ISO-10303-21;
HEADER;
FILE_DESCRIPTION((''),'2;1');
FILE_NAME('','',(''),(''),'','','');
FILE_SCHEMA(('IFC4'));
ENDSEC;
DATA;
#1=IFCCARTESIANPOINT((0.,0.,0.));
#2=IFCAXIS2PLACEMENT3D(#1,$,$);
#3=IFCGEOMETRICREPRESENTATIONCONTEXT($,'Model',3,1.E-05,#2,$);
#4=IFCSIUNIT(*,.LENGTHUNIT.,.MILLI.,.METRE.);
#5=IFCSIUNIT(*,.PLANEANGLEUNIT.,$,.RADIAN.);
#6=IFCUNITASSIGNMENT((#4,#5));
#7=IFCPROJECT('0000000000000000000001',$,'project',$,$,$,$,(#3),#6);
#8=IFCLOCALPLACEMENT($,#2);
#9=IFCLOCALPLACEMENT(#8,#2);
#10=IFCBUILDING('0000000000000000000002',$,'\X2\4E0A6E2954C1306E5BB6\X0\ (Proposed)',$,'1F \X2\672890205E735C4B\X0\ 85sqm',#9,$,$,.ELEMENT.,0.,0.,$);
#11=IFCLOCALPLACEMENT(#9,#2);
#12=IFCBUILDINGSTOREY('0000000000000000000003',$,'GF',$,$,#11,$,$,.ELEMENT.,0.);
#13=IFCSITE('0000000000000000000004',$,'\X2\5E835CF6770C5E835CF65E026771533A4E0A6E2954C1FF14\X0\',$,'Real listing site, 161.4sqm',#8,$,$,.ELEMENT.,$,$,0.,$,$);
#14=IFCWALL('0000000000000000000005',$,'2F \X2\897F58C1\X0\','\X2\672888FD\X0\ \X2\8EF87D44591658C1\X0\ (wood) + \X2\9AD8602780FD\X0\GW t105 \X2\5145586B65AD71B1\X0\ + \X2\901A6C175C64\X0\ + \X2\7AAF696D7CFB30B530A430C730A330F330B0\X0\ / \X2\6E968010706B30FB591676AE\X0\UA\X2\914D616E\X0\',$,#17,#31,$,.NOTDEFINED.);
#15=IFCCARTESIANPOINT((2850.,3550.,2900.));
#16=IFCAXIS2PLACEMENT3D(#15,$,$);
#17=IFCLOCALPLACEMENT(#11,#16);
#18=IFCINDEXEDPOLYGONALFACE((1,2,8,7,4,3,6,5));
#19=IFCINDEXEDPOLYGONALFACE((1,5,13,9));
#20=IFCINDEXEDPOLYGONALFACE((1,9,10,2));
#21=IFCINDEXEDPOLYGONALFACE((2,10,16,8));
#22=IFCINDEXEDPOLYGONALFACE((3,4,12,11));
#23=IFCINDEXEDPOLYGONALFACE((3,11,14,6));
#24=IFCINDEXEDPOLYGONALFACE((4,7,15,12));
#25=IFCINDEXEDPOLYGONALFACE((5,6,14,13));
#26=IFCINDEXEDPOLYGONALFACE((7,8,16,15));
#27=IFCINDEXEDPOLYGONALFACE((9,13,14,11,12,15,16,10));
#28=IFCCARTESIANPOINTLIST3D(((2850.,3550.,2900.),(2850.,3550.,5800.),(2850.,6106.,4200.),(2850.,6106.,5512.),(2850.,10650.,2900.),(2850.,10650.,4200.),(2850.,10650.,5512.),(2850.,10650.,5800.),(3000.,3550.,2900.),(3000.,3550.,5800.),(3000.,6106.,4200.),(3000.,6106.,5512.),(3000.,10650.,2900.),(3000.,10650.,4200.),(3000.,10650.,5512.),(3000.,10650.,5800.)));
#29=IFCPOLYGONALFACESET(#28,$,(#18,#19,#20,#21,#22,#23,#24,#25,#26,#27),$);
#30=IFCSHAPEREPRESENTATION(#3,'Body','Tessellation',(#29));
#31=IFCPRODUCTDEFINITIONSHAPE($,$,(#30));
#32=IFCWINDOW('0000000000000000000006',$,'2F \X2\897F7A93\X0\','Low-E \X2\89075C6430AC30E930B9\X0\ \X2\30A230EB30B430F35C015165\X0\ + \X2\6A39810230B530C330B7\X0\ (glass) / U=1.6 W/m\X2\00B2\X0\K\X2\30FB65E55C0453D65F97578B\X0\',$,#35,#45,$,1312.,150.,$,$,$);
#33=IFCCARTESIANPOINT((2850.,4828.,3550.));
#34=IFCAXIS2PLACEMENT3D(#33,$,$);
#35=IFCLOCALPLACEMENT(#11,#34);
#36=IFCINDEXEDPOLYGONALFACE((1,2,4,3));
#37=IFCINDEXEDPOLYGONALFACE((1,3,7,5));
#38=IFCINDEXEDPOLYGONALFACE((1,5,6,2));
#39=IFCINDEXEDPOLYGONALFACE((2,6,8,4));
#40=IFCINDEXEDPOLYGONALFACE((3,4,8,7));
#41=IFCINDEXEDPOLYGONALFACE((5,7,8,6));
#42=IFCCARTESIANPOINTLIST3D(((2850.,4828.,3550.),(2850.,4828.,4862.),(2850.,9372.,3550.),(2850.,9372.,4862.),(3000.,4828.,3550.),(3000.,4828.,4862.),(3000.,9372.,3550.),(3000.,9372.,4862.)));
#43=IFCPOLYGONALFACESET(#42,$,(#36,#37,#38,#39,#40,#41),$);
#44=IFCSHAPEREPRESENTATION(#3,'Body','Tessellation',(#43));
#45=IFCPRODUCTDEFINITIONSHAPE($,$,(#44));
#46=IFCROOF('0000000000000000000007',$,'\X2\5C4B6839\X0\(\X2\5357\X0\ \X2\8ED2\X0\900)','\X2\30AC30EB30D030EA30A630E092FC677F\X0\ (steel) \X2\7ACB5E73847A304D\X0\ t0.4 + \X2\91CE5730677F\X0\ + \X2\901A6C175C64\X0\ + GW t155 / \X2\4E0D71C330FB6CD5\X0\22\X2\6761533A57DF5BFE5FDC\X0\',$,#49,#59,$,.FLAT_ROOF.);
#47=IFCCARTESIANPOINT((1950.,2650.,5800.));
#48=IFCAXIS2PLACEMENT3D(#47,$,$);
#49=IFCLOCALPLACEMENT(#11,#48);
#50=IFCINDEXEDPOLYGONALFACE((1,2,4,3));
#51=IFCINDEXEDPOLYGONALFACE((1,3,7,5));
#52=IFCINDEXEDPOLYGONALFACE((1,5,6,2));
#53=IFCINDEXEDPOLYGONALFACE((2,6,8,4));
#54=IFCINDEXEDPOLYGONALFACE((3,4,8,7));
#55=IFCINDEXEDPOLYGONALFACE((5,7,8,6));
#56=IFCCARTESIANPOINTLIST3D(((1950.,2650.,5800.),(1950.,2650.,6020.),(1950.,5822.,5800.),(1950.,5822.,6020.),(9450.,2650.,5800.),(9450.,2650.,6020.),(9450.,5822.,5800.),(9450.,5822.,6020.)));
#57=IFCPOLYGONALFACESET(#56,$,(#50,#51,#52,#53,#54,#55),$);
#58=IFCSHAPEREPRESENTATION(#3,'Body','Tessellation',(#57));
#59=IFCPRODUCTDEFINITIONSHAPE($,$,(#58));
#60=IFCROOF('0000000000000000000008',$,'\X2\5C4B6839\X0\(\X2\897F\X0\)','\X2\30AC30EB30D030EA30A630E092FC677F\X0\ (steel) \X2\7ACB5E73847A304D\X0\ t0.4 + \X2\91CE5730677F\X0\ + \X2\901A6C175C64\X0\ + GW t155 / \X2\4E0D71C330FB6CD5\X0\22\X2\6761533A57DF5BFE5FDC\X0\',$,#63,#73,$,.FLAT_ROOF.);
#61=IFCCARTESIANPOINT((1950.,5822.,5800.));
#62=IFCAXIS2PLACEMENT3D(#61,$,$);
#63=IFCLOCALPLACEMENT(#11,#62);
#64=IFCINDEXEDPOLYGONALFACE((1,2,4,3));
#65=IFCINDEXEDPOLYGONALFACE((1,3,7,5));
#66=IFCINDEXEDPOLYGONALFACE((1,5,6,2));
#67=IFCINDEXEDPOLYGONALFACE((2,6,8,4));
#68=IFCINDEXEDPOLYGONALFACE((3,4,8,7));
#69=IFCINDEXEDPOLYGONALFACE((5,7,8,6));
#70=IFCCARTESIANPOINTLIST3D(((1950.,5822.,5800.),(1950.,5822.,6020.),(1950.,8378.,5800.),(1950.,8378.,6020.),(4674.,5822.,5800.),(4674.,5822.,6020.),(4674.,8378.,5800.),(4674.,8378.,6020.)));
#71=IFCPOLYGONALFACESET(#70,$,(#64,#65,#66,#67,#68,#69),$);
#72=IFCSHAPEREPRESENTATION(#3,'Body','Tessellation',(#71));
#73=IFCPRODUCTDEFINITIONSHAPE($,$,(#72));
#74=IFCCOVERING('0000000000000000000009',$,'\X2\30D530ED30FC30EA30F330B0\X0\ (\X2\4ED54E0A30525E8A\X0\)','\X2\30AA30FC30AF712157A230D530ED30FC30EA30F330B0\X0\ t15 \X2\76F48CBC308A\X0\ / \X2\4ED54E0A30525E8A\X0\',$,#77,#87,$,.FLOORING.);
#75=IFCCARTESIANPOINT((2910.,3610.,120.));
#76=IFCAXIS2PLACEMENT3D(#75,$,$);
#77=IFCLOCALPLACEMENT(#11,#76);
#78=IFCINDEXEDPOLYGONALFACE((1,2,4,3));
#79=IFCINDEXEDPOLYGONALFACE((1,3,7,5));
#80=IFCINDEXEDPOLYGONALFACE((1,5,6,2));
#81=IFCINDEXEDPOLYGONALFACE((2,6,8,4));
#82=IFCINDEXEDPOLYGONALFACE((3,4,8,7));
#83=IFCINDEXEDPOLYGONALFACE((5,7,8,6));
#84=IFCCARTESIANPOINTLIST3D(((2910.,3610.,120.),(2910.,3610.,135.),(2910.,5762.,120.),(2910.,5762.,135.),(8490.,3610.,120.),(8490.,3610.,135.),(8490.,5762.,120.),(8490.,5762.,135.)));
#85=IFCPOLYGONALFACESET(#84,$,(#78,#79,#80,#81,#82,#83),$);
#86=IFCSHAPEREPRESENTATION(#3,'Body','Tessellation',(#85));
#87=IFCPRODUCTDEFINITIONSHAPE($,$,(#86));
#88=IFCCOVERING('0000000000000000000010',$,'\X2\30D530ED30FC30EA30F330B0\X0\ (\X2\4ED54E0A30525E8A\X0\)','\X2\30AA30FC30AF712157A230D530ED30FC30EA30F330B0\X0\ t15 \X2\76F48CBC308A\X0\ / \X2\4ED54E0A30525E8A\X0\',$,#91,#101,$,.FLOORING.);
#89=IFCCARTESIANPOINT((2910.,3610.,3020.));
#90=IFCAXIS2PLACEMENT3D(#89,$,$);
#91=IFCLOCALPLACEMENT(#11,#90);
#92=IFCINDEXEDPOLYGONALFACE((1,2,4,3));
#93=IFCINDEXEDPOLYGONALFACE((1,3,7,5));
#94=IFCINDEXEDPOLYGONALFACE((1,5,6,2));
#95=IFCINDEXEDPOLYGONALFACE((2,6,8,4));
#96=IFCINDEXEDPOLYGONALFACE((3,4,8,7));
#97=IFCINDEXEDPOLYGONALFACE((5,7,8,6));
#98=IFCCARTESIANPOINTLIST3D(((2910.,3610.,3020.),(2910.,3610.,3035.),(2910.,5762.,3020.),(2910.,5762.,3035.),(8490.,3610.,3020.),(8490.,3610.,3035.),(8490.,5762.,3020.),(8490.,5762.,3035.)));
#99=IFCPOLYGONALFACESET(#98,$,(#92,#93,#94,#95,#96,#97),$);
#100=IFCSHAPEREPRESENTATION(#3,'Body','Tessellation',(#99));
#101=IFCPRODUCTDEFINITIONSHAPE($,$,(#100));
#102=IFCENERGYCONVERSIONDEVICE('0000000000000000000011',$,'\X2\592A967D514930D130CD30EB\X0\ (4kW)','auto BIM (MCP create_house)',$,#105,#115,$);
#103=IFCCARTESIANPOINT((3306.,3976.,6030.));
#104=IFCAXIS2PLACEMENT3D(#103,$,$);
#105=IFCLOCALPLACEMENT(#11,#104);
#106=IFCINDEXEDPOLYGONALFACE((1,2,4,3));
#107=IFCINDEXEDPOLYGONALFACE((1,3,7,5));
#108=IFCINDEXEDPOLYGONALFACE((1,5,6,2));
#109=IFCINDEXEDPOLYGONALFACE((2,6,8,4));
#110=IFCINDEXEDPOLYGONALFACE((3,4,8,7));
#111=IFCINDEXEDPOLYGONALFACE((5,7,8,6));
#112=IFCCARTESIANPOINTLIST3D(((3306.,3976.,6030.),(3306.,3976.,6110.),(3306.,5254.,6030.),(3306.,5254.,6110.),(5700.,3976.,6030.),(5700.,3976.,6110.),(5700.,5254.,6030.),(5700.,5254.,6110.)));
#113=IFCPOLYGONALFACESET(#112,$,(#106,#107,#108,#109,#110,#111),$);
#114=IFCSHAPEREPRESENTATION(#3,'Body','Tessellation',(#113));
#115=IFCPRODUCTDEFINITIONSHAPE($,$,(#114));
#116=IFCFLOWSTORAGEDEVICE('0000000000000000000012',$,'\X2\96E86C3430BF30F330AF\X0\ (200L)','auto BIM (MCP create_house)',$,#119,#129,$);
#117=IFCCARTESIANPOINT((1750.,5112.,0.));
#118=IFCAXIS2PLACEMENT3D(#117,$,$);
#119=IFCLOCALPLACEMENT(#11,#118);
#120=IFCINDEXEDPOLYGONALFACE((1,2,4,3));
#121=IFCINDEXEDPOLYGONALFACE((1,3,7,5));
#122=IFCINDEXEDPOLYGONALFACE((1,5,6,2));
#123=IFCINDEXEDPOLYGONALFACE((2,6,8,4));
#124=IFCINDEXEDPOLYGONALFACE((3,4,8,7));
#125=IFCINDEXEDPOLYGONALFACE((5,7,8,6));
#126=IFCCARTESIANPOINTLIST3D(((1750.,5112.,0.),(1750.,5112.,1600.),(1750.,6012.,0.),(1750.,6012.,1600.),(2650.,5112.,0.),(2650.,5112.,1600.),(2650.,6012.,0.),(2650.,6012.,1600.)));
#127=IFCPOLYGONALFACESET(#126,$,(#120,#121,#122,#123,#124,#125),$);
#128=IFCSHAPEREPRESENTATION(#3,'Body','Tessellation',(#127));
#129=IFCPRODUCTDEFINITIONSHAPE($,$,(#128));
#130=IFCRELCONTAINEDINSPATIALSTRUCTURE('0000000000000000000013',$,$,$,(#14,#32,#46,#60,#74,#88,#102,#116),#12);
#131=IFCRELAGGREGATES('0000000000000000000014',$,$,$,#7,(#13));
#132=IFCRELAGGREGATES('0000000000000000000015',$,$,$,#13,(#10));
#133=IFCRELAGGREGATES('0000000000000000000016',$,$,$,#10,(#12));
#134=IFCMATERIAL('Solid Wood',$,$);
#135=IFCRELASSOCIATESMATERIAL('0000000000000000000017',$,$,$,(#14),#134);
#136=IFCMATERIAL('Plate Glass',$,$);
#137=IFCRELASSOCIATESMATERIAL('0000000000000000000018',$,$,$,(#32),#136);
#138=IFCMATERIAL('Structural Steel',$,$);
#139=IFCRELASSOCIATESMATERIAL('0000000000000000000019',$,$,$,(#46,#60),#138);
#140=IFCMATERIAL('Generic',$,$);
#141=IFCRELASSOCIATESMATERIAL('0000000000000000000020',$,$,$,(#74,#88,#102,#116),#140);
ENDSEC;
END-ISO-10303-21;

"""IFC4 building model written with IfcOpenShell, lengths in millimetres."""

from ifc_helpers import new_model, si_unit, frame, frame_2d, origin, place, context, project, spatial, rectangle, extrude, material, element, fill, save


model = new_model("IFC4")

# Units and contexts
model_context = context("Model", 3, precision=1e-05, world=origin())
ifc_project = project(units=[si_unit("LENGTHUNIT", "METRE", prefix="MILLI"), si_unit("PLANEANGLEUNIT", "RADIAN")], contexts=[model_context])

# Site, building, storey
site_placement = place(None, origin())
site = spatial("IfcSite", under=ifc_project, at=site_placement, Name="広島県広島市東区上温品４", ObjectType="Real listing site, 161.4sqm", CompositionType="ELEMENT", RefElevation=0.0)
building_placement = place(site_placement, origin())
building = spatial("IfcBuilding", under=site, at=building_placement, Name="上温品の家 (Proposed)", ObjectType="1F 木造平屋 85sqm", CompositionType="ELEMENT", ElevationOfRefHeight=0.0, ElevationOfTerrain=0.0)
storey_placement = place(building_placement, origin())
storey = spatial("IfcBuildingStorey", under=building, at=storey_placement, Name="GF", CompositionType="ELEMENT", Elevation=0.0)

# Shared definitions
ifc_material_1 = material(Name="Solid Wood")
ifc_material_2 = material(Name="Generic")

# Shared definitions
ifc_material_3 = material(Name="Plate Glass")

# Wall, opening, window
wall_1_placement = place(storey_placement, frame((2850.0, 3550.0, 2900.0)))
wall_1 = element("IfcWall", 1, at=wall_1_placement, inside=storey, material=ifc_material_1, Name="2F 西壁", Description="木製 軸組外壁 (wood) + 高性能GW t105 充填断熱 + 通気層 + 窯業系サイディング / 準耐火・外皮UA配慮", PredefinedType="NOTDEFINED", context=model_context, shape_type="SweptSolid", body=[
    extrude(rectangle(XDim=150.0, YDim=7100.0, at=frame_2d((75.0, 3550.0))), frame((2850.0, 3550.0, 2900.0)), (0.0, 0.0, 1.0), 2900.0),
])
opening_1_placement = place(storey_placement, frame((2850.0, 4828.0, 3550.0)))
opening_1 = element("IfcOpeningElement", 2, at=opening_1_placement, cuts=wall_1, PredefinedType="NOTDEFINED", context=model_context, shape_type="SweptSolid", body=[
    extrude(rectangle(XDim=150.0, YDim=4544.0, at=frame_2d((75.0, 2272.0))), frame((2850.0, 4828.0, 3550.0)), (0.0, 0.0, 1.0), 1312.0),
])
window_1_placement = place(storey_placement, frame((2850.0, 4828.0, 3550.0)))
window_1 = element("IfcWindow", 3, at=window_1_placement, inside=storey, material=ifc_material_3, Name="2F 西窓", Description="Low-E 複層ガラス アルゴン封入 + 樹脂サッシ (glass) / U=1.6 W/m²K・日射取得型", OverallHeight=1312.0, OverallWidth=150.0, context=model_context, shape_type="SweptSolid", body=[
    extrude(rectangle(XDim=150.0, YDim=4544.0, at=frame_2d((75.0, 2272.0))), frame((2850.0, 4828.0, 3550.0)), (0.0, 0.0, 1.0), 1312.0),
])
fill(opening_1, window_1)

# Roofs
ifc_material_4 = material(Name="Structural Steel")
roof_1_placement = place(storey_placement, frame((1950.0, 2650.0, 5800.0)))
element("IfcRoof", 4, at=roof_1_placement, inside=storey, material=ifc_material_4, Name="屋根(南 軒900)", Description="ガルバリウム鋼板 (steel) 立平葺き t0.4 + 野地板 + 通気層 + GW t155 / 不燃・法22条区域対応", PredefinedType="FLAT_ROOF", context=model_context, shape_type="SweptSolid", body=[
    extrude(rectangle(XDim=7500.0, YDim=3172.0, at=frame_2d((3750.0, 1586.0))), frame((1950.0, 2650.0, 5800.0)), (0.0, 0.0, 1.0), 220.0),
])
roof_2_placement = place(storey_placement, frame((1950.0, 5822.0, 5800.0)))
element("IfcRoof", 5, at=roof_2_placement, inside=storey, material=ifc_material_4, Name="屋根(西)", Description="ガルバリウム鋼板 (steel) 立平葺き t0.4 + 野地板 + 通気層 + GW t155 / 不燃・法22条区域対応", PredefinedType="FLAT_ROOF", context=model_context, shape_type="SweptSolid", body=[
    extrude(rectangle(XDim=2724.0, YDim=2556.0, at=frame_2d((1362.0, 1278.0))), frame((1950.0, 5822.0, 5800.0)), (0.0, 0.0, 1.0), 220.0),
])

# Coverings
covering_1_placement = place(storey_placement, frame((2910.0, 3610.0, 120.0)))
element("IfcCovering", 6, at=covering_1_placement, inside=storey, material=ifc_material_2, Name="フローリング (仕上げ床)", Description="オーク無垢フローリング t15 直貼り / 仕上げ床", PredefinedType="FLOORING", context=model_context, shape_type="SweptSolid", body=[
    extrude(rectangle(XDim=5580.0, YDim=2152.0, at=frame_2d((2790.0, 1076.0))), frame((2910.0, 3610.0, 120.0)), (0.0, 0.0, 1.0), 15.0),
])
covering_2_placement = place(storey_placement, frame((2910.0, 3610.0, 3020.0)))
element("IfcCovering", 7, at=covering_2_placement, inside=storey, material=ifc_material_2, Name="フローリング (仕上げ床)", Description="オーク無垢フローリング t15 直貼り / 仕上げ床", PredefinedType="FLOORING", context=model_context, shape_type="SweptSolid", body=[
    extrude(rectangle(XDim=5580.0, YDim=2152.0, at=frame_2d((2790.0, 1076.0))), frame((2910.0, 3610.0, 3020.0)), (0.0, 0.0, 1.0), 15.0),
])

# Energy conversion device
energy_conversion_device_placement = place(storey_placement, frame((3306.0, 3976.0, 6030.0)))
element("IfcEnergyConversionDevice", 8, at=energy_conversion_device_placement, inside=storey, material=ifc_material_2, Name="太陽光パネル (4kW)", Description="auto BIM (MCP create_house)", context=model_context, shape_type="SweptSolid", body=[
    extrude(rectangle(XDim=2394.0, YDim=1278.0, at=frame_2d((1197.0, 639.0))), frame((3306.0, 3976.0, 6030.0)), (0.0, 0.0, 1.0), 80.0),
])

# Flow storage device
flow_storage_device_placement = place(storey_placement, frame((1750.0, 5112.0, 0.0)))
element("IfcFlowStorageDevice", 9, at=flow_storage_device_placement, inside=storey, material=ifc_material_2, Name="雨水タンク (200L)", Description="auto BIM (MCP create_house)", context=model_context, shape_type="SweptSolid", body=[
    extrude(rectangle(XDim=900.0, YDim=900.0, at=frame_2d((450.0, 450.0))), frame((1750.0, 5112.0, 0.0)), (0.0, 0.0, 1.0), 1600.0),
])

save(model, "model.ifc")
